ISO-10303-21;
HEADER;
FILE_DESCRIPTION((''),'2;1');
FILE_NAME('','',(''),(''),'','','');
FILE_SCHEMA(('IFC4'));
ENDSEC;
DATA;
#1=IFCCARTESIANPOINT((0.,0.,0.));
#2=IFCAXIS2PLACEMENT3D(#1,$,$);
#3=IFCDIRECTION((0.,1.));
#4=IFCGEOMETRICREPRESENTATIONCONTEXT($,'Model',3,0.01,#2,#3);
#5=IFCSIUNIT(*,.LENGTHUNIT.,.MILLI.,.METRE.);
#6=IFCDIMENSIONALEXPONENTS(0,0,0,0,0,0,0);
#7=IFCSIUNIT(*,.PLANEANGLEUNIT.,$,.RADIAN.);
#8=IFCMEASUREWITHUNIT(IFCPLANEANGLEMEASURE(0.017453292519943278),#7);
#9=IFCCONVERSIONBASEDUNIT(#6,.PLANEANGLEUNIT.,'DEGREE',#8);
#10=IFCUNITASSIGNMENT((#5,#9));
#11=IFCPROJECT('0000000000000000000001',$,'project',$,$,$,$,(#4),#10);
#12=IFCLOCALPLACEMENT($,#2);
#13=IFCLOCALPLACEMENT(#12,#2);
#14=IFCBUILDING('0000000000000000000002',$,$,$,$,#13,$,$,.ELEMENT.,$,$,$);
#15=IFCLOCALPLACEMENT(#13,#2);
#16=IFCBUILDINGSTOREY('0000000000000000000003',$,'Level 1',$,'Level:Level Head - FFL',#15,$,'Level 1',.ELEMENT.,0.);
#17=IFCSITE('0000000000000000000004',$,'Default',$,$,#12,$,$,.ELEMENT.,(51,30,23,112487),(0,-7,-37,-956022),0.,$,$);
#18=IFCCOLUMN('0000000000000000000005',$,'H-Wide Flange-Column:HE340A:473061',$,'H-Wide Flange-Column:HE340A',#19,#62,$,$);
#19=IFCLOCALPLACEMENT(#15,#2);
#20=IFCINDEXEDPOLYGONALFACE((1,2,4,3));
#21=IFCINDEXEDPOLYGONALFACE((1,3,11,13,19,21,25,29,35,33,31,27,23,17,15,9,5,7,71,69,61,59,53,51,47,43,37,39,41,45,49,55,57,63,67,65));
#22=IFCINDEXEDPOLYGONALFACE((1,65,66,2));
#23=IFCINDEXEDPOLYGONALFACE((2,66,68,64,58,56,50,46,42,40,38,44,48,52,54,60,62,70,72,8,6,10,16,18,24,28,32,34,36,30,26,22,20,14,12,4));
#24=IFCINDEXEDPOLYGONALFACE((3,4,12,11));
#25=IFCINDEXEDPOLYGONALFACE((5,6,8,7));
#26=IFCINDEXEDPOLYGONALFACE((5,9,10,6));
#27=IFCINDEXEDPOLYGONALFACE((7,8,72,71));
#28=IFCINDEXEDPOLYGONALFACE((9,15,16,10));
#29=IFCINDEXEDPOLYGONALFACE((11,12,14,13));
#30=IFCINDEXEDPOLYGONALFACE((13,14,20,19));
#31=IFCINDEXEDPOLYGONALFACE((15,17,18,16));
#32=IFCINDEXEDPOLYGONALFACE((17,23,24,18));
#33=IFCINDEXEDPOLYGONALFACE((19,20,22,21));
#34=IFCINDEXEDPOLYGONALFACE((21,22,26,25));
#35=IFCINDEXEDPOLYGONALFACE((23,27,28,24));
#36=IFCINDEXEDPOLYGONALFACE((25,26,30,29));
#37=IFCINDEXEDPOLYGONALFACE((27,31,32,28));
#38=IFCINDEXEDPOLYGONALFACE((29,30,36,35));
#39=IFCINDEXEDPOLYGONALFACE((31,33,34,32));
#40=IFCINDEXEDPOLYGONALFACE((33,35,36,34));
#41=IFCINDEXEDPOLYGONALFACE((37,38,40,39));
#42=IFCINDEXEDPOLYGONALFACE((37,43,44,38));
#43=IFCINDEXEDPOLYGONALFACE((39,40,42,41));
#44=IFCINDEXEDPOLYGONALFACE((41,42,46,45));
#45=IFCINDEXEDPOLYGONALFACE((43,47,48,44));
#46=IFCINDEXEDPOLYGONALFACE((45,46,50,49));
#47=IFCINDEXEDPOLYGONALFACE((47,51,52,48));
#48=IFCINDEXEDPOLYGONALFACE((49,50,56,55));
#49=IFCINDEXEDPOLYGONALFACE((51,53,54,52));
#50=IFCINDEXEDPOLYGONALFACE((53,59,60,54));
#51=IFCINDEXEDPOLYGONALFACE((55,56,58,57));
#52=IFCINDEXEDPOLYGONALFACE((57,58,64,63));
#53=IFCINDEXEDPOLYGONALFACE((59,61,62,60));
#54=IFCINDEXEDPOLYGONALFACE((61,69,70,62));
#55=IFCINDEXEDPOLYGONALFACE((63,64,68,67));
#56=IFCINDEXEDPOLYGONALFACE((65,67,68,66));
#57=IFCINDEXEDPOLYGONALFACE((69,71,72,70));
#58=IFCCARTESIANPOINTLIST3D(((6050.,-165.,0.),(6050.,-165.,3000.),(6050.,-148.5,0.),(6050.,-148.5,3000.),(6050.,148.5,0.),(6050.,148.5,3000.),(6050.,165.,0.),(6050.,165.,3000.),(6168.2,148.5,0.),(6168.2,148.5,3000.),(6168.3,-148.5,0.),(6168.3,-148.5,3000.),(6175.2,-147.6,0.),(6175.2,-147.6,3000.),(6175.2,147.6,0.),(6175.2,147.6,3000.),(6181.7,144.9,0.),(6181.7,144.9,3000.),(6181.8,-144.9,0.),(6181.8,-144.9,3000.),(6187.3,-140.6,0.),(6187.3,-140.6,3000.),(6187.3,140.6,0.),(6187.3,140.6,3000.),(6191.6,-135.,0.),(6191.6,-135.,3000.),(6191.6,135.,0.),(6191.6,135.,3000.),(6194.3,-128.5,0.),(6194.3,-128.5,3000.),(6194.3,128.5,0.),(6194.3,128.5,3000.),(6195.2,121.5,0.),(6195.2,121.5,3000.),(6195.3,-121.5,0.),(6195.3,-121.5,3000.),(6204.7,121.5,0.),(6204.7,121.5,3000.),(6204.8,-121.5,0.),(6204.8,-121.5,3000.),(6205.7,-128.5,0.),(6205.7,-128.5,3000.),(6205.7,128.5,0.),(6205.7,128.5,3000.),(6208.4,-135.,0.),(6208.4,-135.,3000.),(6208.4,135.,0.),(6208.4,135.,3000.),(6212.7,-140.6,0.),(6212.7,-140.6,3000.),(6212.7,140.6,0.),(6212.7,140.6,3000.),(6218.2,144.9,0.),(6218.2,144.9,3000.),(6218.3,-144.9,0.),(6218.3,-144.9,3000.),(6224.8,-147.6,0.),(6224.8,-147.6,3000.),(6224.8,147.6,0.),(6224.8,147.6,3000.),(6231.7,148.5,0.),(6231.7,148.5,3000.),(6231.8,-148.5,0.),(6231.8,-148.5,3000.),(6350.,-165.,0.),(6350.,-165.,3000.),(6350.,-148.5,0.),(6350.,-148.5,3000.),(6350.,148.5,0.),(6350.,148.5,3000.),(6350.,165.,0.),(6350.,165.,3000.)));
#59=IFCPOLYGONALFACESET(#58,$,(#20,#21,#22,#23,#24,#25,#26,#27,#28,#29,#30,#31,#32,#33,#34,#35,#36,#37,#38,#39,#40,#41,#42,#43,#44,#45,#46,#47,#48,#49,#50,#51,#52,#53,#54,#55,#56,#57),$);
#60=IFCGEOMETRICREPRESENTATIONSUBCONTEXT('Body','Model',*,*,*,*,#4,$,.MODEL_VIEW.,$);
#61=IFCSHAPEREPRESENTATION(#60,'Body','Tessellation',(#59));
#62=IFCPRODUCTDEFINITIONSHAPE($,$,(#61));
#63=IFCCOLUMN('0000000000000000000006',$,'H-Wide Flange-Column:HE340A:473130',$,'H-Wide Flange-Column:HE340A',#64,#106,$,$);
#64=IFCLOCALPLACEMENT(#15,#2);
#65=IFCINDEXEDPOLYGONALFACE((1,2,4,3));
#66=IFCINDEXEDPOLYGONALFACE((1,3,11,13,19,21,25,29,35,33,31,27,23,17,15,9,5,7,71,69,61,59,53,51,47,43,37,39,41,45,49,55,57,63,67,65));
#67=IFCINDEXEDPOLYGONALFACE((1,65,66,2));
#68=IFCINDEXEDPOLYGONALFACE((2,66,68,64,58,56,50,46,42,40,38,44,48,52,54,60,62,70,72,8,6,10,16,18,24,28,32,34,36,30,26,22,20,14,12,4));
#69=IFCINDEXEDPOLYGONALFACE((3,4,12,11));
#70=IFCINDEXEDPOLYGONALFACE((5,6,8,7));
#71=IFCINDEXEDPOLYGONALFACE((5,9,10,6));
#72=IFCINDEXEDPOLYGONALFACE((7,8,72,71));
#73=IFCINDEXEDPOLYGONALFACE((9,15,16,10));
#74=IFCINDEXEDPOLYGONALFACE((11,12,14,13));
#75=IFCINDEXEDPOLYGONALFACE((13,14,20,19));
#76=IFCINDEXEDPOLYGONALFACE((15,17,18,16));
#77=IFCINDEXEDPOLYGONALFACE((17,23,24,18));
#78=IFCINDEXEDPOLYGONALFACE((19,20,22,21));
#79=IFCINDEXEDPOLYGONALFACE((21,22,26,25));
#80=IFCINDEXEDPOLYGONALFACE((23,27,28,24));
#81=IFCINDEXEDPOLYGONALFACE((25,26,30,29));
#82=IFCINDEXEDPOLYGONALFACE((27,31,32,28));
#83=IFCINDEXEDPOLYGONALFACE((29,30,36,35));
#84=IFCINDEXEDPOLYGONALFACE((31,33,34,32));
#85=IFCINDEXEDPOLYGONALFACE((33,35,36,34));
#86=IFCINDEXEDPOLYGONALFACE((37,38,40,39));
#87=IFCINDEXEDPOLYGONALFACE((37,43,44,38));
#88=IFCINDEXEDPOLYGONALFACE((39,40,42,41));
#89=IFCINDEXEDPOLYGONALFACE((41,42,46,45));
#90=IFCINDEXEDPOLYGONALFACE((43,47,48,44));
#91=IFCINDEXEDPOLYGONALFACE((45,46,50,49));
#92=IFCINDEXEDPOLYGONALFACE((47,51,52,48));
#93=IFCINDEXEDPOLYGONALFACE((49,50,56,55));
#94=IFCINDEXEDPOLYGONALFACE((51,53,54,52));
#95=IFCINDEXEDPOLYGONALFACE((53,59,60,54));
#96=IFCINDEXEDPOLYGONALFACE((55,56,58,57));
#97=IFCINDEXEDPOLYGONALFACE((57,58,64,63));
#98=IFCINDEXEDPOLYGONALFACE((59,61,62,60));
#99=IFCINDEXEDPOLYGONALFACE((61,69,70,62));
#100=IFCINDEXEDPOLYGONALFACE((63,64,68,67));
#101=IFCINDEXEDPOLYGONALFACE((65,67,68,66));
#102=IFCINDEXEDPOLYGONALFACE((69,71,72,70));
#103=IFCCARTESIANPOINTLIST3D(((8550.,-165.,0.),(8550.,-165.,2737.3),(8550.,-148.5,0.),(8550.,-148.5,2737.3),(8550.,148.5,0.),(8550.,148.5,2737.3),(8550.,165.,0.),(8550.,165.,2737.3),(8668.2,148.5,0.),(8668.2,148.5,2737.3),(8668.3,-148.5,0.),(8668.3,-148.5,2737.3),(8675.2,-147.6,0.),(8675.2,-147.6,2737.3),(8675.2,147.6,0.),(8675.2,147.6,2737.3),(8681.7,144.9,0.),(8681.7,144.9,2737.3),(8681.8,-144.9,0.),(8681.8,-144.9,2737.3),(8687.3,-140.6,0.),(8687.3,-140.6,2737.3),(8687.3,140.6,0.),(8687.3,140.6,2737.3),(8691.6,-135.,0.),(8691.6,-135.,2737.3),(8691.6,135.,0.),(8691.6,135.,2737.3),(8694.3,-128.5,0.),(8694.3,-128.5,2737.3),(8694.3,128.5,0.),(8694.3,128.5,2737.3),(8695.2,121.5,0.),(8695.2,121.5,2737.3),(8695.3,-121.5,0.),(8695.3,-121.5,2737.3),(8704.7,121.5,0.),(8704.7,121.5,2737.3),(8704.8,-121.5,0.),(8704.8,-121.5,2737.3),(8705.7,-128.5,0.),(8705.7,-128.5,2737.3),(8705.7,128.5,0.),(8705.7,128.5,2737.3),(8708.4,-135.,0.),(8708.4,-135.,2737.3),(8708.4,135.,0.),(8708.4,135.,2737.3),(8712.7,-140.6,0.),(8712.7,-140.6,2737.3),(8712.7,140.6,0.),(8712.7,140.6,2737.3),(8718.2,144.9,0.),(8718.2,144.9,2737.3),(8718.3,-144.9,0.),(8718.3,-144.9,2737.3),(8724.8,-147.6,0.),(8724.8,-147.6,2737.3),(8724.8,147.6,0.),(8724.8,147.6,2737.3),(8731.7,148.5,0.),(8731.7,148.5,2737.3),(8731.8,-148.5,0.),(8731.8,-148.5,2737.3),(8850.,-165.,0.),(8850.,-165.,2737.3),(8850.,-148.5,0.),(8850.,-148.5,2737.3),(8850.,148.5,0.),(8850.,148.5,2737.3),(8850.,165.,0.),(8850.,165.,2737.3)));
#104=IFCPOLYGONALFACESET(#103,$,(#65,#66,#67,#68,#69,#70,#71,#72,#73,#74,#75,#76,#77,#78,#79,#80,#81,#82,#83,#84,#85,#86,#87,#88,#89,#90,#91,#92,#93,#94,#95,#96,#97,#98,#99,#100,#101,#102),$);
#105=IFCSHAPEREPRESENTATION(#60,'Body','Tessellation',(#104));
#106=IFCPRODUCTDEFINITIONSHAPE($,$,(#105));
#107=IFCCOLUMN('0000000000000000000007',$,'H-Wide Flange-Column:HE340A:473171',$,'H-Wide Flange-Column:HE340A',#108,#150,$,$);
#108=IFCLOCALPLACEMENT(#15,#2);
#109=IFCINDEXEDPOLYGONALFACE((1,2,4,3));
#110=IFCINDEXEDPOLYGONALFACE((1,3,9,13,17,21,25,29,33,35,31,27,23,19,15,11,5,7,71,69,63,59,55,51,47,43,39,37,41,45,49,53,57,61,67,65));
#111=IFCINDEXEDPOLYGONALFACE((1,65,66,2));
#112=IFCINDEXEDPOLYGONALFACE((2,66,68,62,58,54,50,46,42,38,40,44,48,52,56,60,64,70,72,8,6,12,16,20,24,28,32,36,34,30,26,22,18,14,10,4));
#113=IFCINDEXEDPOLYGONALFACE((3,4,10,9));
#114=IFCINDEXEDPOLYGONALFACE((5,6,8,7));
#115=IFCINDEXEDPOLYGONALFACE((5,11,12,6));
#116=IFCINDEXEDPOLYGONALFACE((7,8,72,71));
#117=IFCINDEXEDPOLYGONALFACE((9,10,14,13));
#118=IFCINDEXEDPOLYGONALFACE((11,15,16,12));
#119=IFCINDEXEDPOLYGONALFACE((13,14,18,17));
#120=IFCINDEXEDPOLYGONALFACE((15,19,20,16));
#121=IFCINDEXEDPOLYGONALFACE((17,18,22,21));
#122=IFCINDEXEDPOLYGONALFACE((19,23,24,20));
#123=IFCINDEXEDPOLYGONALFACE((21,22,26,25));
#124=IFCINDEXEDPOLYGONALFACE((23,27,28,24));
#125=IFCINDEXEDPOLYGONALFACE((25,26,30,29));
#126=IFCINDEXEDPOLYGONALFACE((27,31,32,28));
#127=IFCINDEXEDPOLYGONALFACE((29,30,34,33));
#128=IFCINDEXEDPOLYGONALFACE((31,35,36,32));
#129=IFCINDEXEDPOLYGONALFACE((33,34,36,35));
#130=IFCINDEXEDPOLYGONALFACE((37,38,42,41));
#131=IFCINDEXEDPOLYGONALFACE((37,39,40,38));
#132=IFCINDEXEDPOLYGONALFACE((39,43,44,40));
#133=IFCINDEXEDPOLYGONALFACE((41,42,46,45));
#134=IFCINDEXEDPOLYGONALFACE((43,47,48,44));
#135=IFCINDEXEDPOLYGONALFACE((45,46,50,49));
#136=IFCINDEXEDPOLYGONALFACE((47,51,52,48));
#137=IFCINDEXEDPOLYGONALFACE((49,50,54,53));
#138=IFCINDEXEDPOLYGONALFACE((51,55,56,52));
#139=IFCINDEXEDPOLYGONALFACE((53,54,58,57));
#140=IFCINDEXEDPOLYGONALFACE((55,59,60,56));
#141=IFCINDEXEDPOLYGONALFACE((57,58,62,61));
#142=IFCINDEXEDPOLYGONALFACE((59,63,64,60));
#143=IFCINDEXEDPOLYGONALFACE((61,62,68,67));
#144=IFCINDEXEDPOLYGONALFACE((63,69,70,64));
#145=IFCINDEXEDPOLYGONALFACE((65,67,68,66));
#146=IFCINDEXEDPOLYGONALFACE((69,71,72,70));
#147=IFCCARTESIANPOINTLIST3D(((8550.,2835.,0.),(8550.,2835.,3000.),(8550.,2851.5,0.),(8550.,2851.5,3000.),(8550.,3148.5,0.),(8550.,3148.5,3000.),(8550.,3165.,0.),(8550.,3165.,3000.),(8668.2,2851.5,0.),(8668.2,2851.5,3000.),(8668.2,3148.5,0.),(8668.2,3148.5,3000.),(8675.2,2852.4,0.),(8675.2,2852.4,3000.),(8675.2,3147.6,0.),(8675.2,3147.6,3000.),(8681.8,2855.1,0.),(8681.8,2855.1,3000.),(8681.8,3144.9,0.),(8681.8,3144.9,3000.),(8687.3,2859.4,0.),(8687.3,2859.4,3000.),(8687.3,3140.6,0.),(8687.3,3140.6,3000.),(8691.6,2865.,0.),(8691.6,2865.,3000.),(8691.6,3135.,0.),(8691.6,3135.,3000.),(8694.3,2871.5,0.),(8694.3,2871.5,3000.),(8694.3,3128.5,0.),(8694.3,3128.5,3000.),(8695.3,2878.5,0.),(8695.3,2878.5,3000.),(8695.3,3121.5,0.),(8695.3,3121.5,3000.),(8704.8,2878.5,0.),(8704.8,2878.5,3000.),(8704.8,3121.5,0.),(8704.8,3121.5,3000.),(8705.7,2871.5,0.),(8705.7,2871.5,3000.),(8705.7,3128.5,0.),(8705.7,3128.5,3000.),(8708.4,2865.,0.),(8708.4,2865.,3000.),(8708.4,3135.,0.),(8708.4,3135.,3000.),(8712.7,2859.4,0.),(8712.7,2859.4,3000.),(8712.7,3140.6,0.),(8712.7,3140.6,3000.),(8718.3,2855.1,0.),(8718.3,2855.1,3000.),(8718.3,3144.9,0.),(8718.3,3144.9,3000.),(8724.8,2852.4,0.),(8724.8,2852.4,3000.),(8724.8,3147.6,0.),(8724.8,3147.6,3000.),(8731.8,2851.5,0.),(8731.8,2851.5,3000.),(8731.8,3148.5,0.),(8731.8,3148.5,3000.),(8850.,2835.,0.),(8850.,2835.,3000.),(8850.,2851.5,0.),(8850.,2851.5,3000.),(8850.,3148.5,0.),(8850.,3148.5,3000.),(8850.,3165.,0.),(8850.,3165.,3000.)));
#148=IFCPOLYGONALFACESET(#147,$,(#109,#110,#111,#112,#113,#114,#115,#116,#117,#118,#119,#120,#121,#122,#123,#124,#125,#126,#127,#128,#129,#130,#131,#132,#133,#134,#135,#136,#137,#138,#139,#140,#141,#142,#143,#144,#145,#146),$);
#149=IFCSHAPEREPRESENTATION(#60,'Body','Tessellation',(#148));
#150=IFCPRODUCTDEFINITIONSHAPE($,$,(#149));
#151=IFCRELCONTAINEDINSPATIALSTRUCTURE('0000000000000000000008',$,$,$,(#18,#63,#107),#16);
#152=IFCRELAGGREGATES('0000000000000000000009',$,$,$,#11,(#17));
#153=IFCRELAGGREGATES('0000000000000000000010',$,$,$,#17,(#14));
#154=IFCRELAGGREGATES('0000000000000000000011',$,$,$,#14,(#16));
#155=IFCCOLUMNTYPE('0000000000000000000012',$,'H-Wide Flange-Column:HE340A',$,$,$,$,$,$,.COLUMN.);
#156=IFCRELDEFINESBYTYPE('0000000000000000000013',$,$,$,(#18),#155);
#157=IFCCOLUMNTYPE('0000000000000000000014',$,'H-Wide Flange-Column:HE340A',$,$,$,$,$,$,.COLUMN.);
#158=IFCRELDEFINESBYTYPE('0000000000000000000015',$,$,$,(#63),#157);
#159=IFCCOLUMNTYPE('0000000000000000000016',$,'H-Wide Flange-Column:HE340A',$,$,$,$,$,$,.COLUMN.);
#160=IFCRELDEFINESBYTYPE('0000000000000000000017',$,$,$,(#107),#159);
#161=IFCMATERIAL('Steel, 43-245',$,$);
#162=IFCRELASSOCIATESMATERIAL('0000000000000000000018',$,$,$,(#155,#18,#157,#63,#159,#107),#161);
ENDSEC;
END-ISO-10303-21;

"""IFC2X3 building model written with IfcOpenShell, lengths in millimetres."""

from ifc_helpers import new_model, entity, si_unit, converted_unit, direction, frame, frame_2d, origin, place, context, subcontext, project, spatial, polyline, circle_curve, parameter, trimmed, segment, composite_curve, outline, extrude, source, transform, mapped, material, type_object, type_shapes, element, save


model = new_model("IFC2X3")

# Units and contexts
model_context = context("Model", 3, precision=0.01, world=origin(), true_north=direction((0.0, 1.0)))
body_context = subcontext(model_context, "Body", "Model", "MODEL_VIEW")
ifc_project = project(units=[si_unit("LENGTHUNIT", "METRE", prefix="MILLI"), converted_unit("PLANEANGLEUNIT", "DEGREE", entity("IfcPlaneAngleMeasure", 0.017453292519943278), si_unit("PLANEANGLEUNIT", "RADIAN"), dimensions=[0, 0, 0, 0, 0, 0, 0])], contexts=[model_context])

# Site, building, storey
site_placement = place(None, origin())
site = spatial("IfcSite", under=ifc_project, at=site_placement, Name="Default", CompositionType="ELEMENT", RefLatitude=(51, 30, 23, 112487), RefLongitude=(0, -7, -37, -956022), RefElevation=0.0)
building_placement = place(site_placement, origin())
building = spatial("IfcBuilding", under=site, at=building_placement, CompositionType="ELEMENT")
storey_placement = place(building_placement, origin())
storey = spatial("IfcBuildingStorey", under=building, at=storey_placement, Name="Level 1", ObjectType="Level:Level Head - FFL", LongName="Level 1", CompositionType="ELEMENT", Elevation=0.0)

# Columns
ifc_material = material(Name="Steel, 43-245")
column_type_1 = type_object("IfcColumnType", Name="H-Wide Flange-Column:HE340A", PredefinedType="COLUMN", material=ifc_material)
shared_shape_1 = source(origin(), body_context, "Body", "SweptSolid", [
    extrude(outline(composite_curve([segment(polyline([(148.5, -150.0), (165.0, -150.0)]), True, "CONTINUOUS"), segment(polyline([(165.0, -150.0), (165.0, 150.0)]), True, "CONTINUOUS"), segment(polyline([(165.0, 150.0), (148.5, 150.0)]), True, "CONTINUOUS"), segment(polyline([(148.5, 150.0), (148.5, 31.8)]), True, "CONTINUOUS"), segment(trimmed(circle_curve(frame_2d((121.5, 31.8), x_axis=(1.0, 0.0)), 27.0), [parameter(270.0)], [parameter(0.0)], True, "PARAMETER"), False, "CONTINUOUS"), segment(polyline([(121.5, 4.8), (-121.5, 4.7)]), True, "CONTINUOUS"), segment(trimmed(circle_curve(frame_2d((-121.5, 31.7), x_axis=(0.0, -1.0)), 27.0), [parameter(270.0)], [parameter(0.0)], True, "PARAMETER"), False, "CONTINUOUS"), segment(polyline([(-148.5, 31.7), (-148.5, 150.0)]), True, "CONTINUOUS"), segment(polyline([(-148.5, 150.0), (-165.0, 150.0)]), True, "CONTINUOUS"), segment(polyline([(-165.0, 150.0), (-165.0, -150.0)]), True, "CONTINUOUS"), segment(polyline([(-165.0, -150.0), (-148.5, -150.0)]), True, "CONTINUOUS"), segment(polyline([(-148.5, -150.0), (-148.5, -31.8)]), True, "CONTINUOUS"), segment(trimmed(circle_curve(frame_2d((-121.5, -31.8), x_axis=(-1.0, 0.0)), 27.0), [parameter(270.0)], [parameter(0.0)], True, "PARAMETER"), False, "CONTINUOUS"), segment(polyline([(-121.5, -4.8), (121.5, -4.7)]), True, "CONTINUOUS"), segment(trimmed(circle_curve(frame_2d((121.5, -31.7), x_axis=(0.0, 1.0)), 27.0), [parameter(270.0)], [parameter(0.0)], True, "PARAMETER"), False, "CONTINUOUS"), segment(polyline([(148.5, -31.7), (148.5, -150.0)]), True, "CONTINUOUS")], self_intersect=False)), frame((6200.0, 0.0, 0.0), z_axis=(0.0, 0.0, 1.0), x_axis=(0.0, -1.0, 0.0)), (0.0, 0.0, 1.0), 3000.0),
])
type_shapes(column_type_1, [shared_shape_1])
column_1_placement = place(storey_placement, origin())
element("IfcColumn", 1, at=column_1_placement, inside=storey, type_object=column_type_1, material=ifc_material, Name="H-Wide Flange-Column:HE340A:473061", ObjectType="H-Wide Flange-Column:HE340A", context=body_context, shape_type="MappedRepresentation", body=[
    mapped(shared_shape_1, transform((0.0, 0.0, 0.0), scale=1.0)),
])
column_type_2 = type_object("IfcColumnType", Name="H-Wide Flange-Column:HE340A", PredefinedType="COLUMN", material=ifc_material)
shared_shape_2 = source(origin(), body_context, "Body", "SweptSolid", [
    extrude(outline(composite_curve([segment(polyline([(148.5, -150.0), (165.0, -150.0)]), True, "CONTINUOUS"), segment(polyline([(165.0, -150.0), (165.0, 150.0)]), True, "CONTINUOUS"), segment(polyline([(165.0, 150.0), (148.5, 150.0)]), True, "CONTINUOUS"), segment(polyline([(148.5, 150.0), (148.5, 31.8)]), True, "CONTINUOUS"), segment(trimmed(circle_curve(frame_2d((121.5, 31.8), x_axis=(1.0, 0.0)), 27.0), [parameter(270.0)], [parameter(0.0)], True, "PARAMETER"), False, "CONTINUOUS"), segment(polyline([(121.5, 4.8), (-121.5, 4.7)]), True, "CONTINUOUS"), segment(trimmed(circle_curve(frame_2d((-121.5, 31.7), x_axis=(0.0, -1.0)), 27.0), [parameter(270.0)], [parameter(0.0)], True, "PARAMETER"), False, "CONTINUOUS"), segment(polyline([(-148.5, 31.7), (-148.5, 150.0)]), True, "CONTINUOUS"), segment(polyline([(-148.5, 150.0), (-165.0, 150.0)]), True, "CONTINUOUS"), segment(polyline([(-165.0, 150.0), (-165.0, -150.0)]), True, "CONTINUOUS"), segment(polyline([(-165.0, -150.0), (-148.5, -150.0)]), True, "CONTINUOUS"), segment(polyline([(-148.5, -150.0), (-148.5, -31.8)]), True, "CONTINUOUS"), segment(trimmed(circle_curve(frame_2d((-121.5, -31.8), x_axis=(-1.0, 0.0)), 27.0), [parameter(270.0)], [parameter(0.0)], True, "PARAMETER"), False, "CONTINUOUS"), segment(polyline([(-121.5, -4.8), (121.5, -4.7)]), True, "CONTINUOUS"), segment(trimmed(circle_curve(frame_2d((121.5, -31.7), x_axis=(0.0, 1.0)), 27.0), [parameter(270.0)], [parameter(0.0)], True, "PARAMETER"), False, "CONTINUOUS"), segment(polyline([(148.5, -31.7), (148.5, -150.0)]), True, "CONTINUOUS")], self_intersect=False)), frame((8700.0, 0.0, 0.0), z_axis=(0.0, 0.0, 1.0), x_axis=(0.0, -1.0, 0.0)), (0.0, 0.0, 1.0), 2737.3),
])
type_shapes(column_type_2, [shared_shape_2])
column_2_placement = place(storey_placement, origin())
element("IfcColumn", 2, at=column_2_placement, inside=storey, type_object=column_type_2, material=ifc_material, Name="H-Wide Flange-Column:HE340A:473130", ObjectType="H-Wide Flange-Column:HE340A", context=body_context, shape_type="MappedRepresentation", body=[
    mapped(shared_shape_2, transform((0.0, 0.0, 0.0), scale=1.0)),
])
column_type_3 = type_object("IfcColumnType", Name="H-Wide Flange-Column:HE340A", PredefinedType="COLUMN", material=ifc_material)
shared_shape_3 = source(origin(), body_context, "Body", "SweptSolid", [
    extrude(outline(composite_curve([segment(polyline([(148.5, -150.0), (165.0, -150.0)]), True, "CONTINUOUS"), segment(polyline([(165.0, -150.0), (165.0, 150.0)]), True, "CONTINUOUS"), segment(polyline([(165.0, 150.0), (148.5, 150.0)]), True, "CONTINUOUS"), segment(polyline([(148.5, 150.0), (148.5, 31.8)]), True, "CONTINUOUS"), segment(trimmed(circle_curve(frame_2d((121.5, 31.8), x_axis=(1.0, 0.0)), 27.0), [parameter(270.0)], [parameter(0.0)], True, "PARAMETER"), False, "CONTINUOUS"), segment(polyline([(121.5, 4.8), (-121.5, 4.8)]), True, "CONTINUOUS"), segment(trimmed(circle_curve(frame_2d((-121.5, 31.8), x_axis=(0.0, -1.0)), 27.0), [parameter(270.0)], [parameter(0.0)], True, "PARAMETER"), False, "CONTINUOUS"), segment(polyline([(-148.5, 31.8), (-148.5, 150.0)]), True, "CONTINUOUS"), segment(polyline([(-148.5, 150.0), (-165.0, 150.0)]), True, "CONTINUOUS"), segment(polyline([(-165.0, 150.0), (-165.0, -150.0)]), True, "CONTINUOUS"), segment(polyline([(-165.0, -150.0), (-148.5, -150.0)]), True, "CONTINUOUS"), segment(polyline([(-148.5, -150.0), (-148.5, -31.8)]), True, "CONTINUOUS"), segment(trimmed(circle_curve(frame_2d((-121.5, -31.8), x_axis=(-1.0, 0.0)), 27.0), [parameter(270.0)], [parameter(0.0)], True, "PARAMETER"), False, "CONTINUOUS"), segment(polyline([(-121.5, -4.8), (121.5, -4.8)]), True, "CONTINUOUS"), segment(trimmed(circle_curve(frame_2d((121.5, -31.8), x_axis=(0.0, 1.0)), 27.0), [parameter(270.0)], [parameter(0.0)], True, "PARAMETER"), False, "CONTINUOUS"), segment(polyline([(148.5, -31.8), (148.5, -150.0)]), True, "CONTINUOUS")], self_intersect=False)), frame((8700.0, 3000.0, 0.0), z_axis=(0.0, 0.0, 1.0), x_axis=(0.0, -1.0, 0.0)), (0.0, 0.0, 1.0), 3000.0),
])
type_shapes(column_type_3, [shared_shape_3])
column_3_placement = place(storey_placement, origin())
element("IfcColumn", 3, at=column_3_placement, inside=storey, type_object=column_type_3, material=ifc_material, Name="H-Wide Flange-Column:HE340A:473171", ObjectType="H-Wide Flange-Column:HE340A", context=body_context, shape_type="MappedRepresentation", body=[
    mapped(shared_shape_3, transform((0.0, 0.0, 0.0), scale=1.0)),
])

save(model, "model.ifc")
